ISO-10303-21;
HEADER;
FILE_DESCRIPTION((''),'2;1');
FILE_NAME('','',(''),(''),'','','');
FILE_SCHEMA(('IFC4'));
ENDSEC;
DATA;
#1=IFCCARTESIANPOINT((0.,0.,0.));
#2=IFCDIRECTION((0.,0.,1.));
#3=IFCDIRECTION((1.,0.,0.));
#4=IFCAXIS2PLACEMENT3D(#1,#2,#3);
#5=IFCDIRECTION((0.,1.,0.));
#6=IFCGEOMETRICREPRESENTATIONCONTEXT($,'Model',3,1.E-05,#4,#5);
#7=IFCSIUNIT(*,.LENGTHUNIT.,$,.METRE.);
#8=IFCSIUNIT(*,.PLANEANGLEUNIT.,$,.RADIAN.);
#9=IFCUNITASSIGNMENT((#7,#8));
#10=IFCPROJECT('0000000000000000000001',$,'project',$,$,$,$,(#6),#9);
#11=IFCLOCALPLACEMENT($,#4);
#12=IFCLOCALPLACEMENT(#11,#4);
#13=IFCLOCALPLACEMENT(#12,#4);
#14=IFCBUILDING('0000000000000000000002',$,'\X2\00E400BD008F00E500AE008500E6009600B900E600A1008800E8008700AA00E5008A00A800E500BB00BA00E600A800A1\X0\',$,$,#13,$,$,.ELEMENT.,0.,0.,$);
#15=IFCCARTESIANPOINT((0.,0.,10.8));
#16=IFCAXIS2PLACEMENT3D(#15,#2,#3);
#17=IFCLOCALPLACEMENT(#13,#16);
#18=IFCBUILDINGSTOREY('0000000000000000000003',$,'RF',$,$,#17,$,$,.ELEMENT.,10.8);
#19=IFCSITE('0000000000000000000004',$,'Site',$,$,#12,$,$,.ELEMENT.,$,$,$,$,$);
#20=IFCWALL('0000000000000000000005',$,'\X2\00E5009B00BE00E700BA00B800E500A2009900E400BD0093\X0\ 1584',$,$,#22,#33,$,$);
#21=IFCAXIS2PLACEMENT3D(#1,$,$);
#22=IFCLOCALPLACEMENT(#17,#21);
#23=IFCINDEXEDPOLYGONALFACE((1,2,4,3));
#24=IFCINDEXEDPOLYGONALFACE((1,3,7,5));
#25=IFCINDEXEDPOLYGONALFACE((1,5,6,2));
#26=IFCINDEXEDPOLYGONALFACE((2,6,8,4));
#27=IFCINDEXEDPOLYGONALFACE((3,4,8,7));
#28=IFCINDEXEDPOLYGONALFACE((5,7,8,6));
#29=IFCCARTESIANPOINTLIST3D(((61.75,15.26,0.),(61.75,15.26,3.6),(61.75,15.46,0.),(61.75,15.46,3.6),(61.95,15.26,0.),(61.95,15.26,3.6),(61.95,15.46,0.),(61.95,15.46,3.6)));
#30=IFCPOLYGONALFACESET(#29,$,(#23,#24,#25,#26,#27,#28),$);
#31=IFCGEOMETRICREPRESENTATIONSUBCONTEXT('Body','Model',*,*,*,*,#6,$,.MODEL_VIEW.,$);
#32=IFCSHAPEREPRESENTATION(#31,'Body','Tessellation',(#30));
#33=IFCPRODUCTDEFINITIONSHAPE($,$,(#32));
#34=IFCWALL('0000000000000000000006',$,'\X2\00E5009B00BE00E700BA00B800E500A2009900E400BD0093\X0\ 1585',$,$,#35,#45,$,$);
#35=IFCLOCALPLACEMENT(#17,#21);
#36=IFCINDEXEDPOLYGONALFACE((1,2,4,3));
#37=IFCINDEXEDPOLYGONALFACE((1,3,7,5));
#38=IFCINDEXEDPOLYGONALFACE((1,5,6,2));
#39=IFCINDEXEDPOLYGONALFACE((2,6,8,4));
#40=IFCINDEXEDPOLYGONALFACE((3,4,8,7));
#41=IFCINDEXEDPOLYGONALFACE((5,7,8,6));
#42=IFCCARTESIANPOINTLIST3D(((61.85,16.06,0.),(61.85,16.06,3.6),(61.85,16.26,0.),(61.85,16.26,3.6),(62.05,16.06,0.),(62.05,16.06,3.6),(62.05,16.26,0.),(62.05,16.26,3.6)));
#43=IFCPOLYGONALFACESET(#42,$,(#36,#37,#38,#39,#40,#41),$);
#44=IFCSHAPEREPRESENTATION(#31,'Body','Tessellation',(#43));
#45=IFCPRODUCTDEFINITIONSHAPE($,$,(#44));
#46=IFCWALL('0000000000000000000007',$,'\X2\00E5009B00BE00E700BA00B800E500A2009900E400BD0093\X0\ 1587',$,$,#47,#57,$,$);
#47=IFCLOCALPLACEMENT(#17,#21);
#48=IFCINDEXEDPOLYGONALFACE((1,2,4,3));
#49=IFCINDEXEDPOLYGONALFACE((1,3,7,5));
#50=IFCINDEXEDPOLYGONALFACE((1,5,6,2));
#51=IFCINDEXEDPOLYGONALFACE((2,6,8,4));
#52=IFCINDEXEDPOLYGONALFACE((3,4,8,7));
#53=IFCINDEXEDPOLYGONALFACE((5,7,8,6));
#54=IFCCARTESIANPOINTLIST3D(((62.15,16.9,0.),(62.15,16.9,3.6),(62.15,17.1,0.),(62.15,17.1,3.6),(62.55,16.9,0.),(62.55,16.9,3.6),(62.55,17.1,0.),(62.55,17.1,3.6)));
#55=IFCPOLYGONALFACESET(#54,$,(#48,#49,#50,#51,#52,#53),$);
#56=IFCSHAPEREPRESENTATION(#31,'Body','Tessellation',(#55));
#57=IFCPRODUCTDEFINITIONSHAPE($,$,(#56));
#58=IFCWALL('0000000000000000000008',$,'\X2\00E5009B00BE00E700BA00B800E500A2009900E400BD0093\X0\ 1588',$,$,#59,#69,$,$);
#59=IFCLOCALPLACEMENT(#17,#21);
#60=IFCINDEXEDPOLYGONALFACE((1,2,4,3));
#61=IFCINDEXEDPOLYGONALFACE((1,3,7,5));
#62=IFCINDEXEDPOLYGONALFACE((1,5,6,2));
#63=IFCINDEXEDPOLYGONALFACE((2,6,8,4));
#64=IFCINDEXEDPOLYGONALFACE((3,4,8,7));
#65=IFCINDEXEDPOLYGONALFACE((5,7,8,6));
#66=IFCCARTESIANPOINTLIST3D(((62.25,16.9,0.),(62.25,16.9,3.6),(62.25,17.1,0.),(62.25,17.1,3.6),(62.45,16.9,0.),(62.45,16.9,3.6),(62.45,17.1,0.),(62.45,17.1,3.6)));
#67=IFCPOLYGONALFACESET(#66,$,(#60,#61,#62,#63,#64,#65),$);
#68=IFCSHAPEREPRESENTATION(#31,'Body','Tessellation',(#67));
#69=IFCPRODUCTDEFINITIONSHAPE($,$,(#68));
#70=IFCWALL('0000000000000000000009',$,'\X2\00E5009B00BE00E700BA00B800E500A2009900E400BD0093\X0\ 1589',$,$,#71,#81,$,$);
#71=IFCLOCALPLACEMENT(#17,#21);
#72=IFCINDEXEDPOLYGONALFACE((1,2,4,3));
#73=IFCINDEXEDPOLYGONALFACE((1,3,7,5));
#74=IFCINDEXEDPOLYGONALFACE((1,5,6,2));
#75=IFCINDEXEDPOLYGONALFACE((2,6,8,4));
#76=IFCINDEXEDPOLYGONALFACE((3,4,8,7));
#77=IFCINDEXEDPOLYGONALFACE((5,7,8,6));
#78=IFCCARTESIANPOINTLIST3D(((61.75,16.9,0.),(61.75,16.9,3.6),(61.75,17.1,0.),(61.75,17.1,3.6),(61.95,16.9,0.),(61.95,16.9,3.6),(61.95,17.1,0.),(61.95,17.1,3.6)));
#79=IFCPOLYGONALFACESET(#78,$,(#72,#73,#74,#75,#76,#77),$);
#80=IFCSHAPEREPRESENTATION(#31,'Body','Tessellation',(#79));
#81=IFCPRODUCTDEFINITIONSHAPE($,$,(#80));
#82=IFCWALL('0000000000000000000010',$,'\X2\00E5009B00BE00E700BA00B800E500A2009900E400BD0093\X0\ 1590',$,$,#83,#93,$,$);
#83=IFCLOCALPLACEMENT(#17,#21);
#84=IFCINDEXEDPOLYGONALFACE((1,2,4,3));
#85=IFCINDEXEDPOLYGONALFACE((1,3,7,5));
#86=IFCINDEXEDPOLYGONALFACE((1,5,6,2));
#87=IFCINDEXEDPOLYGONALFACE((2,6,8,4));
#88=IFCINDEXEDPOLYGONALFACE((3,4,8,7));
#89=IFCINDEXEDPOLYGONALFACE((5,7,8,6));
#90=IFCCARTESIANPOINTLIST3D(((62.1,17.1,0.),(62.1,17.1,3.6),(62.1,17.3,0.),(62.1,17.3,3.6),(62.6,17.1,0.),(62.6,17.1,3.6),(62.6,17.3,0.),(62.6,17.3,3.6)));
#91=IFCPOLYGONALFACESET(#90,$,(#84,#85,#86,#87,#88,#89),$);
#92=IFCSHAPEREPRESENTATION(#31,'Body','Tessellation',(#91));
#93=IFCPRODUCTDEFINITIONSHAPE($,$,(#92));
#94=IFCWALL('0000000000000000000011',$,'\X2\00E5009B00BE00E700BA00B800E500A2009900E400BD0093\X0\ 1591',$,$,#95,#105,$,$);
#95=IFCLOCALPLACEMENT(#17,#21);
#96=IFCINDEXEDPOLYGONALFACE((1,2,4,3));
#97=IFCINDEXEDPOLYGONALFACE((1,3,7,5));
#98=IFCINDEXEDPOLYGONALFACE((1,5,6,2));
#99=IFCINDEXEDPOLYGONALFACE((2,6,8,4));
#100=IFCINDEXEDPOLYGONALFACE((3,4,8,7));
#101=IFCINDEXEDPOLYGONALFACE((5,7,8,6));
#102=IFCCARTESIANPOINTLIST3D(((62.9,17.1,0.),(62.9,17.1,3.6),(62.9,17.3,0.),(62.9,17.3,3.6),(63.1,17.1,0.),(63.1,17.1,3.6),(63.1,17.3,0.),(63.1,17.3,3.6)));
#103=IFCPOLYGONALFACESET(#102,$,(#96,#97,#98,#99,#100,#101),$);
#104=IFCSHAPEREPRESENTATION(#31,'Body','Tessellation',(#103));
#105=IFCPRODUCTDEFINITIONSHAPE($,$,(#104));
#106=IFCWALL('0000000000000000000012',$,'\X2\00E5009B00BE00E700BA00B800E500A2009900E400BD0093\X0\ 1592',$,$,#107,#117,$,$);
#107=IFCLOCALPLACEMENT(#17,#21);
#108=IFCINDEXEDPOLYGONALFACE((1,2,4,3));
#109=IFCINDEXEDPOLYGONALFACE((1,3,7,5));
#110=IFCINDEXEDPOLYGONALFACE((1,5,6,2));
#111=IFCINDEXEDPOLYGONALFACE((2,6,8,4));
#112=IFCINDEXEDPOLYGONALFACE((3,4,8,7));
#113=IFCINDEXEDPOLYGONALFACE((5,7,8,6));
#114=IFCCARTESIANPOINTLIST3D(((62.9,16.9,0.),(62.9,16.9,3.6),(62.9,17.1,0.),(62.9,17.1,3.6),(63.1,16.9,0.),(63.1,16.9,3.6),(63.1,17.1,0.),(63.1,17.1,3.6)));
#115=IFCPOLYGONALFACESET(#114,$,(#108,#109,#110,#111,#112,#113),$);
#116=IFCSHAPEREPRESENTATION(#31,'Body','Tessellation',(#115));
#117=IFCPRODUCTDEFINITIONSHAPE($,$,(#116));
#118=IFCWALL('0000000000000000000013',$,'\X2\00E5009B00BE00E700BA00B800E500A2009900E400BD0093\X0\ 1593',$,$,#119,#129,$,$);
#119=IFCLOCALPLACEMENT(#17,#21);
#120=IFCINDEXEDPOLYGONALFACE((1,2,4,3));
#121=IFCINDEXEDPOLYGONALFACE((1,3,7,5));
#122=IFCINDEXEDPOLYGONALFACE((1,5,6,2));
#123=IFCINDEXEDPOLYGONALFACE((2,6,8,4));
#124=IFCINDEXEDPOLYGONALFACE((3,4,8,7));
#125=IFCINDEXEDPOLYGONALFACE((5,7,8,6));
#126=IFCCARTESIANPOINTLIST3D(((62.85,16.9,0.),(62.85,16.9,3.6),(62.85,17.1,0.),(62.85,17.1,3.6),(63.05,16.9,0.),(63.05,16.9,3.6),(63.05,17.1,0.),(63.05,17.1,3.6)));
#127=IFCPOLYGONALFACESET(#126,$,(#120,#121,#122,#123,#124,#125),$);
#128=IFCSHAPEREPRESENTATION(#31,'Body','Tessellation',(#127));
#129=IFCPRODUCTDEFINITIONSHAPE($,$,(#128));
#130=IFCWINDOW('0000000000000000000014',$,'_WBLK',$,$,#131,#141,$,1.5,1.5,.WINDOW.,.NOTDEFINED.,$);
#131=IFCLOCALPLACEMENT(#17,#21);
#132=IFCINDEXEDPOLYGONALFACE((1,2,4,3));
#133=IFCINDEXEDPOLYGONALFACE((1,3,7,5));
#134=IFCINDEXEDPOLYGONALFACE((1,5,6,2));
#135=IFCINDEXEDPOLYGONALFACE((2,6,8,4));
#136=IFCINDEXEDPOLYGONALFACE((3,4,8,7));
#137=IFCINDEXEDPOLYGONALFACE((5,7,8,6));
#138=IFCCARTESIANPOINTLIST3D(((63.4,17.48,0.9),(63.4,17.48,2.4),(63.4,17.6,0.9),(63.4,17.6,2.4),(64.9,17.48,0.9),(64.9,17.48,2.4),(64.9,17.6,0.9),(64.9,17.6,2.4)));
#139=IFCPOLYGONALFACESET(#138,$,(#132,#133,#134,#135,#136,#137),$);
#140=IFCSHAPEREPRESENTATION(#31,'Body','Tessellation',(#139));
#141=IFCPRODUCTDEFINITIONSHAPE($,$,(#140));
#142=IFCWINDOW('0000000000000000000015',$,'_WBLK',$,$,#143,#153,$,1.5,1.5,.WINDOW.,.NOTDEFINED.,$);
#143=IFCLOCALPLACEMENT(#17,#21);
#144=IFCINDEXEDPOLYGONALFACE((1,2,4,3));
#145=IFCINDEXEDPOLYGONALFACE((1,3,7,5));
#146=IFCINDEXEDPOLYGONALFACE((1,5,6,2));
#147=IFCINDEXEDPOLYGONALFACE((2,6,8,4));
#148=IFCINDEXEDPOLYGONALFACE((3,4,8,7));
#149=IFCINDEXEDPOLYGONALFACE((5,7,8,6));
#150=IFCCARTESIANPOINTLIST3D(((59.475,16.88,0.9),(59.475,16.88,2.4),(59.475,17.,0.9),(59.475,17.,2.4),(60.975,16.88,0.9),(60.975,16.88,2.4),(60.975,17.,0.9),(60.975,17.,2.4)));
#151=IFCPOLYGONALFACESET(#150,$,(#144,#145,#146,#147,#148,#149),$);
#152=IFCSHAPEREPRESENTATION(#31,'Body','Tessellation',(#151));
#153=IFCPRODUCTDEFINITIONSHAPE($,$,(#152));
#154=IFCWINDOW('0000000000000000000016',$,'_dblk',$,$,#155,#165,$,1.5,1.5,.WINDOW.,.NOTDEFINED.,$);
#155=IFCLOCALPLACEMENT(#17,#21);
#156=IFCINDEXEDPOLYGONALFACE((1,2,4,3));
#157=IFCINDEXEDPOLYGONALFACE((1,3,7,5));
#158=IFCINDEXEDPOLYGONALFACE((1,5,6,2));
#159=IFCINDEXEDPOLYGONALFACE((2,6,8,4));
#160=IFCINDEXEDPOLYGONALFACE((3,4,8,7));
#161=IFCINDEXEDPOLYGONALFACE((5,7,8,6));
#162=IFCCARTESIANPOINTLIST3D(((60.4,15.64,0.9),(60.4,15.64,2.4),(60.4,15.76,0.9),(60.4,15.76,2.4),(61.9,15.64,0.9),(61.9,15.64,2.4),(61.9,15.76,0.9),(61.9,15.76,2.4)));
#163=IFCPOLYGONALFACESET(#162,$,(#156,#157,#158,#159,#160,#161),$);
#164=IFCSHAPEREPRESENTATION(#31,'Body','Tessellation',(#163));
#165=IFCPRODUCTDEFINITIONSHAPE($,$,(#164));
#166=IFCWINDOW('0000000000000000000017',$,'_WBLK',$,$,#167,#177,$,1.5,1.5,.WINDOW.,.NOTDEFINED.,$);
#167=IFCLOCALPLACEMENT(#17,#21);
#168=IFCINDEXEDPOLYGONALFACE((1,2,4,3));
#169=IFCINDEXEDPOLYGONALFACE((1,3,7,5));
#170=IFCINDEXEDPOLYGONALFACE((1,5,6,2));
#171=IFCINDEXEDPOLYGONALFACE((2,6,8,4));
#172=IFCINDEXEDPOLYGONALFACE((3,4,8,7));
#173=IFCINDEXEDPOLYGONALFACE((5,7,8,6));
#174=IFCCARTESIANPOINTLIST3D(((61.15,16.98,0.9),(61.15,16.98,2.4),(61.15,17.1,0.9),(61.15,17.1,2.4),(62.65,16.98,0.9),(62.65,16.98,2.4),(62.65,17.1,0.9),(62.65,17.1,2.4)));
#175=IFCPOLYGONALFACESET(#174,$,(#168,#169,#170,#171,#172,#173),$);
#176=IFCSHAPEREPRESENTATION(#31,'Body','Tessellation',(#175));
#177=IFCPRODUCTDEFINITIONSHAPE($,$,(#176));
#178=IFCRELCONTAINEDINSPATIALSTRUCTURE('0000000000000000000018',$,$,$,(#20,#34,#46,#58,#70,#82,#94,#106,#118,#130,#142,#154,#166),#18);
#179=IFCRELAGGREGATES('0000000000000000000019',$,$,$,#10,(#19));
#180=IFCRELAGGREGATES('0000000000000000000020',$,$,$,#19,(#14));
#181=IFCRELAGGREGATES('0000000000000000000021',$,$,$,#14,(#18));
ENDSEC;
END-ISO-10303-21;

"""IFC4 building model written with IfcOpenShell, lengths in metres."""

from ifc_helpers import new_model, si_unit, direction, frame, frame_2d, origin_with_axes, place, context, subcontext, project, spatial, rectangle, extrude, element, save


model = new_model("IFC4")

# Units and contexts
model_context = context("Model", 3, precision=1e-05, world=origin_with_axes(), true_north=direction((0.0, 1.0, 0.0)))
body_context = subcontext(model_context, "Body", "Model", "MODEL_VIEW")
ifc_project = project(units=[si_unit("LENGTHUNIT", "METRE"), si_unit("PLANEANGLEUNIT", "RADIAN")], contexts=[model_context])

# Site, building, storey
placement = place(None, origin_with_axes())
site_placement = place(placement, origin_with_axes())
site = spatial("IfcSite", under=ifc_project, at=site_placement, Name="Site", CompositionType="ELEMENT")
building_placement = place(site_placement, origin_with_axes())
building = spatial("IfcBuilding", under=site, at=building_placement, Name="ä½\u008få®\u0085æ\u0096¹æ¡\u0088è\u0087ªå\u008a¨å»ºæ¨¡", CompositionType="ELEMENT", ElevationOfRefHeight=0.0, ElevationOfTerrain=0.0)
storey_placement = place(building_placement, frame((0.0, 0.0, 10.8), z_axis=(0.0, 0.0, 1.0), x_axis=(1.0, 0.0, 0.0)))
storey = spatial("IfcBuildingStorey", under=building, at=storey_placement, Name="RF", CompositionType="ELEMENT", Elevation=10.8)

# Walls
for number, where, z_axis, x_axis, name in (
    (1, (61.85, 15.36, 0.0), (0.0, 0.0, 1.0), (0.0, -1.0, 0.0), "å\u009b¾çº¸å¢\u0099ä½\u0093 1584"),
    (2, (61.95, 16.16, 0.0), (0.0, 0.0, 1.0), (-1.0, 0.0, 0.0), "å\u009b¾çº¸å¢\u0099ä½\u0093 1585"),
):
    element("IfcWall", number, at=place(storey_placement, frame(where, z_axis=z_axis, x_axis=x_axis)), inside=storey, Name=name, context=body_context, shape_type="SweptSolid", body=[
        extrude(rectangle(XDim=0.2, YDim=0.2, at=frame_2d((0.0, 0.0), x_axis=(1.0, 0.0, 0.0))), frame((0.0, 0.0, 0.0), z_axis=(0.0, 0.0, 1.0)), (0.0, 0.0, 1.0), 3.6),
    ])
wall_1_placement = place(storey_placement, frame((62.35, 17.0, 0.0), z_axis=(0.0, 0.0, 1.0), x_axis=(-1.0, 0.0, 0.0)))
element("IfcWall", 3, at=wall_1_placement, inside=storey, Name="å\u009b¾çº¸å¢\u0099ä½\u0093 1587", context=body_context, shape_type="SweptSolid", body=[
    extrude(rectangle(XDim=0.4, YDim=0.2, at=frame_2d((0.0, 0.0), x_axis=(1.0, 0.0, 0.0))), frame((0.0, 0.0, 0.0), z_axis=(0.0, 0.0, 1.0)), (0.0, 0.0, 1.0), 3.6),
])
for number, where, z_axis, x_axis, name in (
    (4, (62.35, 17.0, 0.0), (0.0, 0.0, 1.0), (0.0, 1.0, 0.0), "å\u009b¾çº¸å¢\u0099ä½\u0093 1588"),
    (5, (61.85, 17.0, 0.0), (0.0, 0.0, 1.0), (0.0, 1.0, 0.0), "å\u009b¾çº¸å¢\u0099ä½\u0093 1589"),
):
    element("IfcWall", number, at=place(storey_placement, frame(where, z_axis=z_axis, x_axis=x_axis)), inside=storey, Name=name, context=body_context, shape_type="SweptSolid", body=[
        extrude(rectangle(XDim=0.2, YDim=0.2, at=frame_2d((0.0, 0.0), x_axis=(1.0, 0.0, 0.0))), frame((0.0, 0.0, 0.0), z_axis=(0.0, 0.0, 1.0)), (0.0, 0.0, 1.0), 3.6),
    ])
wall_2_placement = place(storey_placement, frame((62.35, 17.2, 0.0), z_axis=(0.0, 0.0, 1.0), x_axis=(-1.0, 0.0, 0.0)))
element("IfcWall", 6, at=wall_2_placement, inside=storey, Name="å\u009b¾çº¸å¢\u0099ä½\u0093 1590", context=body_context, shape_type="SweptSolid", body=[
    extrude(rectangle(XDim=0.5, YDim=0.2, at=frame_2d((0.0, 0.0), x_axis=(1.0, 0.0, 0.0))), frame((0.0, 0.0, 0.0), z_axis=(0.0, 0.0, 1.0)), (0.0, 0.0, 1.0), 3.6),
])
for number, where, z_axis, x_axis, name in (
    (7, (63.0, 17.2, 0.0), (0.0, 0.0, 1.0), (-1.0, 0.0, 0.0), "å\u009b¾çº¸å¢\u0099ä½\u0093 1591"),
    (8, (63.0, 17.0, 0.0), (0.0, 0.0, 1.0), (-1.0, 0.0, 0.0), "å\u009b¾çº¸å¢\u0099ä½\u0093 1592"),
    (9, (62.95, 17.0, 0.0), (0.0, 0.0, 1.0), (0.0, 1.0, 0.0), "å\u009b¾çº¸å¢\u0099ä½\u0093 1593"),
):
    element("IfcWall", number, at=place(storey_placement, frame(where, z_axis=z_axis, x_axis=x_axis)), inside=storey, Name=name, context=body_context, shape_type="SweptSolid", body=[
        extrude(rectangle(XDim=0.2, YDim=0.2, at=frame_2d((0.0, 0.0), x_axis=(1.0, 0.0, 0.0))), frame((0.0, 0.0, 0.0), z_axis=(0.0, 0.0, 1.0)), (0.0, 0.0, 1.0), 3.6),
    ])

# Windows
for number, where, z_axis, x_axis, name in (
    (10, (64.15, 17.54, 0.9), (0.0, 0.0, 1.0), (1.0, 0.0, 0.0), "_WBLK"),
    (11, (60.225, 16.94, 0.9), (0.0, 0.0, 1.0), (1.0, 0.0, 0.0), "_WBLK"),
    (12, (61.15, 15.7, 0.9), (0.0, 0.0, 1.0), (1.0, 0.0, 0.0), "_dblk"),
    (13, (61.9, 17.04, 0.9), (0.0, 0.0, 1.0), (1.0, 0.0, 0.0), "_WBLK"),
):
    element("IfcWindow", number, at=place(storey_placement, frame(where, z_axis=z_axis, x_axis=x_axis)), inside=storey, Name=name, OverallHeight=1.5, OverallWidth=1.5, PartitioningType="NOTDEFINED", PredefinedType="WINDOW", context=body_context, shape_type="SweptSolid", body=[
        extrude(rectangle(XDim=1.5, YDim=0.12, at=frame_2d((0.0, 0.0), x_axis=(1.0, 0.0, 0.0))), frame((0.0, 0.0, 0.0), z_axis=(0.0, 0.0, 1.0)), (0.0, 0.0, 1.0), 1.5),
    ])

save(model, "model.ifc")
